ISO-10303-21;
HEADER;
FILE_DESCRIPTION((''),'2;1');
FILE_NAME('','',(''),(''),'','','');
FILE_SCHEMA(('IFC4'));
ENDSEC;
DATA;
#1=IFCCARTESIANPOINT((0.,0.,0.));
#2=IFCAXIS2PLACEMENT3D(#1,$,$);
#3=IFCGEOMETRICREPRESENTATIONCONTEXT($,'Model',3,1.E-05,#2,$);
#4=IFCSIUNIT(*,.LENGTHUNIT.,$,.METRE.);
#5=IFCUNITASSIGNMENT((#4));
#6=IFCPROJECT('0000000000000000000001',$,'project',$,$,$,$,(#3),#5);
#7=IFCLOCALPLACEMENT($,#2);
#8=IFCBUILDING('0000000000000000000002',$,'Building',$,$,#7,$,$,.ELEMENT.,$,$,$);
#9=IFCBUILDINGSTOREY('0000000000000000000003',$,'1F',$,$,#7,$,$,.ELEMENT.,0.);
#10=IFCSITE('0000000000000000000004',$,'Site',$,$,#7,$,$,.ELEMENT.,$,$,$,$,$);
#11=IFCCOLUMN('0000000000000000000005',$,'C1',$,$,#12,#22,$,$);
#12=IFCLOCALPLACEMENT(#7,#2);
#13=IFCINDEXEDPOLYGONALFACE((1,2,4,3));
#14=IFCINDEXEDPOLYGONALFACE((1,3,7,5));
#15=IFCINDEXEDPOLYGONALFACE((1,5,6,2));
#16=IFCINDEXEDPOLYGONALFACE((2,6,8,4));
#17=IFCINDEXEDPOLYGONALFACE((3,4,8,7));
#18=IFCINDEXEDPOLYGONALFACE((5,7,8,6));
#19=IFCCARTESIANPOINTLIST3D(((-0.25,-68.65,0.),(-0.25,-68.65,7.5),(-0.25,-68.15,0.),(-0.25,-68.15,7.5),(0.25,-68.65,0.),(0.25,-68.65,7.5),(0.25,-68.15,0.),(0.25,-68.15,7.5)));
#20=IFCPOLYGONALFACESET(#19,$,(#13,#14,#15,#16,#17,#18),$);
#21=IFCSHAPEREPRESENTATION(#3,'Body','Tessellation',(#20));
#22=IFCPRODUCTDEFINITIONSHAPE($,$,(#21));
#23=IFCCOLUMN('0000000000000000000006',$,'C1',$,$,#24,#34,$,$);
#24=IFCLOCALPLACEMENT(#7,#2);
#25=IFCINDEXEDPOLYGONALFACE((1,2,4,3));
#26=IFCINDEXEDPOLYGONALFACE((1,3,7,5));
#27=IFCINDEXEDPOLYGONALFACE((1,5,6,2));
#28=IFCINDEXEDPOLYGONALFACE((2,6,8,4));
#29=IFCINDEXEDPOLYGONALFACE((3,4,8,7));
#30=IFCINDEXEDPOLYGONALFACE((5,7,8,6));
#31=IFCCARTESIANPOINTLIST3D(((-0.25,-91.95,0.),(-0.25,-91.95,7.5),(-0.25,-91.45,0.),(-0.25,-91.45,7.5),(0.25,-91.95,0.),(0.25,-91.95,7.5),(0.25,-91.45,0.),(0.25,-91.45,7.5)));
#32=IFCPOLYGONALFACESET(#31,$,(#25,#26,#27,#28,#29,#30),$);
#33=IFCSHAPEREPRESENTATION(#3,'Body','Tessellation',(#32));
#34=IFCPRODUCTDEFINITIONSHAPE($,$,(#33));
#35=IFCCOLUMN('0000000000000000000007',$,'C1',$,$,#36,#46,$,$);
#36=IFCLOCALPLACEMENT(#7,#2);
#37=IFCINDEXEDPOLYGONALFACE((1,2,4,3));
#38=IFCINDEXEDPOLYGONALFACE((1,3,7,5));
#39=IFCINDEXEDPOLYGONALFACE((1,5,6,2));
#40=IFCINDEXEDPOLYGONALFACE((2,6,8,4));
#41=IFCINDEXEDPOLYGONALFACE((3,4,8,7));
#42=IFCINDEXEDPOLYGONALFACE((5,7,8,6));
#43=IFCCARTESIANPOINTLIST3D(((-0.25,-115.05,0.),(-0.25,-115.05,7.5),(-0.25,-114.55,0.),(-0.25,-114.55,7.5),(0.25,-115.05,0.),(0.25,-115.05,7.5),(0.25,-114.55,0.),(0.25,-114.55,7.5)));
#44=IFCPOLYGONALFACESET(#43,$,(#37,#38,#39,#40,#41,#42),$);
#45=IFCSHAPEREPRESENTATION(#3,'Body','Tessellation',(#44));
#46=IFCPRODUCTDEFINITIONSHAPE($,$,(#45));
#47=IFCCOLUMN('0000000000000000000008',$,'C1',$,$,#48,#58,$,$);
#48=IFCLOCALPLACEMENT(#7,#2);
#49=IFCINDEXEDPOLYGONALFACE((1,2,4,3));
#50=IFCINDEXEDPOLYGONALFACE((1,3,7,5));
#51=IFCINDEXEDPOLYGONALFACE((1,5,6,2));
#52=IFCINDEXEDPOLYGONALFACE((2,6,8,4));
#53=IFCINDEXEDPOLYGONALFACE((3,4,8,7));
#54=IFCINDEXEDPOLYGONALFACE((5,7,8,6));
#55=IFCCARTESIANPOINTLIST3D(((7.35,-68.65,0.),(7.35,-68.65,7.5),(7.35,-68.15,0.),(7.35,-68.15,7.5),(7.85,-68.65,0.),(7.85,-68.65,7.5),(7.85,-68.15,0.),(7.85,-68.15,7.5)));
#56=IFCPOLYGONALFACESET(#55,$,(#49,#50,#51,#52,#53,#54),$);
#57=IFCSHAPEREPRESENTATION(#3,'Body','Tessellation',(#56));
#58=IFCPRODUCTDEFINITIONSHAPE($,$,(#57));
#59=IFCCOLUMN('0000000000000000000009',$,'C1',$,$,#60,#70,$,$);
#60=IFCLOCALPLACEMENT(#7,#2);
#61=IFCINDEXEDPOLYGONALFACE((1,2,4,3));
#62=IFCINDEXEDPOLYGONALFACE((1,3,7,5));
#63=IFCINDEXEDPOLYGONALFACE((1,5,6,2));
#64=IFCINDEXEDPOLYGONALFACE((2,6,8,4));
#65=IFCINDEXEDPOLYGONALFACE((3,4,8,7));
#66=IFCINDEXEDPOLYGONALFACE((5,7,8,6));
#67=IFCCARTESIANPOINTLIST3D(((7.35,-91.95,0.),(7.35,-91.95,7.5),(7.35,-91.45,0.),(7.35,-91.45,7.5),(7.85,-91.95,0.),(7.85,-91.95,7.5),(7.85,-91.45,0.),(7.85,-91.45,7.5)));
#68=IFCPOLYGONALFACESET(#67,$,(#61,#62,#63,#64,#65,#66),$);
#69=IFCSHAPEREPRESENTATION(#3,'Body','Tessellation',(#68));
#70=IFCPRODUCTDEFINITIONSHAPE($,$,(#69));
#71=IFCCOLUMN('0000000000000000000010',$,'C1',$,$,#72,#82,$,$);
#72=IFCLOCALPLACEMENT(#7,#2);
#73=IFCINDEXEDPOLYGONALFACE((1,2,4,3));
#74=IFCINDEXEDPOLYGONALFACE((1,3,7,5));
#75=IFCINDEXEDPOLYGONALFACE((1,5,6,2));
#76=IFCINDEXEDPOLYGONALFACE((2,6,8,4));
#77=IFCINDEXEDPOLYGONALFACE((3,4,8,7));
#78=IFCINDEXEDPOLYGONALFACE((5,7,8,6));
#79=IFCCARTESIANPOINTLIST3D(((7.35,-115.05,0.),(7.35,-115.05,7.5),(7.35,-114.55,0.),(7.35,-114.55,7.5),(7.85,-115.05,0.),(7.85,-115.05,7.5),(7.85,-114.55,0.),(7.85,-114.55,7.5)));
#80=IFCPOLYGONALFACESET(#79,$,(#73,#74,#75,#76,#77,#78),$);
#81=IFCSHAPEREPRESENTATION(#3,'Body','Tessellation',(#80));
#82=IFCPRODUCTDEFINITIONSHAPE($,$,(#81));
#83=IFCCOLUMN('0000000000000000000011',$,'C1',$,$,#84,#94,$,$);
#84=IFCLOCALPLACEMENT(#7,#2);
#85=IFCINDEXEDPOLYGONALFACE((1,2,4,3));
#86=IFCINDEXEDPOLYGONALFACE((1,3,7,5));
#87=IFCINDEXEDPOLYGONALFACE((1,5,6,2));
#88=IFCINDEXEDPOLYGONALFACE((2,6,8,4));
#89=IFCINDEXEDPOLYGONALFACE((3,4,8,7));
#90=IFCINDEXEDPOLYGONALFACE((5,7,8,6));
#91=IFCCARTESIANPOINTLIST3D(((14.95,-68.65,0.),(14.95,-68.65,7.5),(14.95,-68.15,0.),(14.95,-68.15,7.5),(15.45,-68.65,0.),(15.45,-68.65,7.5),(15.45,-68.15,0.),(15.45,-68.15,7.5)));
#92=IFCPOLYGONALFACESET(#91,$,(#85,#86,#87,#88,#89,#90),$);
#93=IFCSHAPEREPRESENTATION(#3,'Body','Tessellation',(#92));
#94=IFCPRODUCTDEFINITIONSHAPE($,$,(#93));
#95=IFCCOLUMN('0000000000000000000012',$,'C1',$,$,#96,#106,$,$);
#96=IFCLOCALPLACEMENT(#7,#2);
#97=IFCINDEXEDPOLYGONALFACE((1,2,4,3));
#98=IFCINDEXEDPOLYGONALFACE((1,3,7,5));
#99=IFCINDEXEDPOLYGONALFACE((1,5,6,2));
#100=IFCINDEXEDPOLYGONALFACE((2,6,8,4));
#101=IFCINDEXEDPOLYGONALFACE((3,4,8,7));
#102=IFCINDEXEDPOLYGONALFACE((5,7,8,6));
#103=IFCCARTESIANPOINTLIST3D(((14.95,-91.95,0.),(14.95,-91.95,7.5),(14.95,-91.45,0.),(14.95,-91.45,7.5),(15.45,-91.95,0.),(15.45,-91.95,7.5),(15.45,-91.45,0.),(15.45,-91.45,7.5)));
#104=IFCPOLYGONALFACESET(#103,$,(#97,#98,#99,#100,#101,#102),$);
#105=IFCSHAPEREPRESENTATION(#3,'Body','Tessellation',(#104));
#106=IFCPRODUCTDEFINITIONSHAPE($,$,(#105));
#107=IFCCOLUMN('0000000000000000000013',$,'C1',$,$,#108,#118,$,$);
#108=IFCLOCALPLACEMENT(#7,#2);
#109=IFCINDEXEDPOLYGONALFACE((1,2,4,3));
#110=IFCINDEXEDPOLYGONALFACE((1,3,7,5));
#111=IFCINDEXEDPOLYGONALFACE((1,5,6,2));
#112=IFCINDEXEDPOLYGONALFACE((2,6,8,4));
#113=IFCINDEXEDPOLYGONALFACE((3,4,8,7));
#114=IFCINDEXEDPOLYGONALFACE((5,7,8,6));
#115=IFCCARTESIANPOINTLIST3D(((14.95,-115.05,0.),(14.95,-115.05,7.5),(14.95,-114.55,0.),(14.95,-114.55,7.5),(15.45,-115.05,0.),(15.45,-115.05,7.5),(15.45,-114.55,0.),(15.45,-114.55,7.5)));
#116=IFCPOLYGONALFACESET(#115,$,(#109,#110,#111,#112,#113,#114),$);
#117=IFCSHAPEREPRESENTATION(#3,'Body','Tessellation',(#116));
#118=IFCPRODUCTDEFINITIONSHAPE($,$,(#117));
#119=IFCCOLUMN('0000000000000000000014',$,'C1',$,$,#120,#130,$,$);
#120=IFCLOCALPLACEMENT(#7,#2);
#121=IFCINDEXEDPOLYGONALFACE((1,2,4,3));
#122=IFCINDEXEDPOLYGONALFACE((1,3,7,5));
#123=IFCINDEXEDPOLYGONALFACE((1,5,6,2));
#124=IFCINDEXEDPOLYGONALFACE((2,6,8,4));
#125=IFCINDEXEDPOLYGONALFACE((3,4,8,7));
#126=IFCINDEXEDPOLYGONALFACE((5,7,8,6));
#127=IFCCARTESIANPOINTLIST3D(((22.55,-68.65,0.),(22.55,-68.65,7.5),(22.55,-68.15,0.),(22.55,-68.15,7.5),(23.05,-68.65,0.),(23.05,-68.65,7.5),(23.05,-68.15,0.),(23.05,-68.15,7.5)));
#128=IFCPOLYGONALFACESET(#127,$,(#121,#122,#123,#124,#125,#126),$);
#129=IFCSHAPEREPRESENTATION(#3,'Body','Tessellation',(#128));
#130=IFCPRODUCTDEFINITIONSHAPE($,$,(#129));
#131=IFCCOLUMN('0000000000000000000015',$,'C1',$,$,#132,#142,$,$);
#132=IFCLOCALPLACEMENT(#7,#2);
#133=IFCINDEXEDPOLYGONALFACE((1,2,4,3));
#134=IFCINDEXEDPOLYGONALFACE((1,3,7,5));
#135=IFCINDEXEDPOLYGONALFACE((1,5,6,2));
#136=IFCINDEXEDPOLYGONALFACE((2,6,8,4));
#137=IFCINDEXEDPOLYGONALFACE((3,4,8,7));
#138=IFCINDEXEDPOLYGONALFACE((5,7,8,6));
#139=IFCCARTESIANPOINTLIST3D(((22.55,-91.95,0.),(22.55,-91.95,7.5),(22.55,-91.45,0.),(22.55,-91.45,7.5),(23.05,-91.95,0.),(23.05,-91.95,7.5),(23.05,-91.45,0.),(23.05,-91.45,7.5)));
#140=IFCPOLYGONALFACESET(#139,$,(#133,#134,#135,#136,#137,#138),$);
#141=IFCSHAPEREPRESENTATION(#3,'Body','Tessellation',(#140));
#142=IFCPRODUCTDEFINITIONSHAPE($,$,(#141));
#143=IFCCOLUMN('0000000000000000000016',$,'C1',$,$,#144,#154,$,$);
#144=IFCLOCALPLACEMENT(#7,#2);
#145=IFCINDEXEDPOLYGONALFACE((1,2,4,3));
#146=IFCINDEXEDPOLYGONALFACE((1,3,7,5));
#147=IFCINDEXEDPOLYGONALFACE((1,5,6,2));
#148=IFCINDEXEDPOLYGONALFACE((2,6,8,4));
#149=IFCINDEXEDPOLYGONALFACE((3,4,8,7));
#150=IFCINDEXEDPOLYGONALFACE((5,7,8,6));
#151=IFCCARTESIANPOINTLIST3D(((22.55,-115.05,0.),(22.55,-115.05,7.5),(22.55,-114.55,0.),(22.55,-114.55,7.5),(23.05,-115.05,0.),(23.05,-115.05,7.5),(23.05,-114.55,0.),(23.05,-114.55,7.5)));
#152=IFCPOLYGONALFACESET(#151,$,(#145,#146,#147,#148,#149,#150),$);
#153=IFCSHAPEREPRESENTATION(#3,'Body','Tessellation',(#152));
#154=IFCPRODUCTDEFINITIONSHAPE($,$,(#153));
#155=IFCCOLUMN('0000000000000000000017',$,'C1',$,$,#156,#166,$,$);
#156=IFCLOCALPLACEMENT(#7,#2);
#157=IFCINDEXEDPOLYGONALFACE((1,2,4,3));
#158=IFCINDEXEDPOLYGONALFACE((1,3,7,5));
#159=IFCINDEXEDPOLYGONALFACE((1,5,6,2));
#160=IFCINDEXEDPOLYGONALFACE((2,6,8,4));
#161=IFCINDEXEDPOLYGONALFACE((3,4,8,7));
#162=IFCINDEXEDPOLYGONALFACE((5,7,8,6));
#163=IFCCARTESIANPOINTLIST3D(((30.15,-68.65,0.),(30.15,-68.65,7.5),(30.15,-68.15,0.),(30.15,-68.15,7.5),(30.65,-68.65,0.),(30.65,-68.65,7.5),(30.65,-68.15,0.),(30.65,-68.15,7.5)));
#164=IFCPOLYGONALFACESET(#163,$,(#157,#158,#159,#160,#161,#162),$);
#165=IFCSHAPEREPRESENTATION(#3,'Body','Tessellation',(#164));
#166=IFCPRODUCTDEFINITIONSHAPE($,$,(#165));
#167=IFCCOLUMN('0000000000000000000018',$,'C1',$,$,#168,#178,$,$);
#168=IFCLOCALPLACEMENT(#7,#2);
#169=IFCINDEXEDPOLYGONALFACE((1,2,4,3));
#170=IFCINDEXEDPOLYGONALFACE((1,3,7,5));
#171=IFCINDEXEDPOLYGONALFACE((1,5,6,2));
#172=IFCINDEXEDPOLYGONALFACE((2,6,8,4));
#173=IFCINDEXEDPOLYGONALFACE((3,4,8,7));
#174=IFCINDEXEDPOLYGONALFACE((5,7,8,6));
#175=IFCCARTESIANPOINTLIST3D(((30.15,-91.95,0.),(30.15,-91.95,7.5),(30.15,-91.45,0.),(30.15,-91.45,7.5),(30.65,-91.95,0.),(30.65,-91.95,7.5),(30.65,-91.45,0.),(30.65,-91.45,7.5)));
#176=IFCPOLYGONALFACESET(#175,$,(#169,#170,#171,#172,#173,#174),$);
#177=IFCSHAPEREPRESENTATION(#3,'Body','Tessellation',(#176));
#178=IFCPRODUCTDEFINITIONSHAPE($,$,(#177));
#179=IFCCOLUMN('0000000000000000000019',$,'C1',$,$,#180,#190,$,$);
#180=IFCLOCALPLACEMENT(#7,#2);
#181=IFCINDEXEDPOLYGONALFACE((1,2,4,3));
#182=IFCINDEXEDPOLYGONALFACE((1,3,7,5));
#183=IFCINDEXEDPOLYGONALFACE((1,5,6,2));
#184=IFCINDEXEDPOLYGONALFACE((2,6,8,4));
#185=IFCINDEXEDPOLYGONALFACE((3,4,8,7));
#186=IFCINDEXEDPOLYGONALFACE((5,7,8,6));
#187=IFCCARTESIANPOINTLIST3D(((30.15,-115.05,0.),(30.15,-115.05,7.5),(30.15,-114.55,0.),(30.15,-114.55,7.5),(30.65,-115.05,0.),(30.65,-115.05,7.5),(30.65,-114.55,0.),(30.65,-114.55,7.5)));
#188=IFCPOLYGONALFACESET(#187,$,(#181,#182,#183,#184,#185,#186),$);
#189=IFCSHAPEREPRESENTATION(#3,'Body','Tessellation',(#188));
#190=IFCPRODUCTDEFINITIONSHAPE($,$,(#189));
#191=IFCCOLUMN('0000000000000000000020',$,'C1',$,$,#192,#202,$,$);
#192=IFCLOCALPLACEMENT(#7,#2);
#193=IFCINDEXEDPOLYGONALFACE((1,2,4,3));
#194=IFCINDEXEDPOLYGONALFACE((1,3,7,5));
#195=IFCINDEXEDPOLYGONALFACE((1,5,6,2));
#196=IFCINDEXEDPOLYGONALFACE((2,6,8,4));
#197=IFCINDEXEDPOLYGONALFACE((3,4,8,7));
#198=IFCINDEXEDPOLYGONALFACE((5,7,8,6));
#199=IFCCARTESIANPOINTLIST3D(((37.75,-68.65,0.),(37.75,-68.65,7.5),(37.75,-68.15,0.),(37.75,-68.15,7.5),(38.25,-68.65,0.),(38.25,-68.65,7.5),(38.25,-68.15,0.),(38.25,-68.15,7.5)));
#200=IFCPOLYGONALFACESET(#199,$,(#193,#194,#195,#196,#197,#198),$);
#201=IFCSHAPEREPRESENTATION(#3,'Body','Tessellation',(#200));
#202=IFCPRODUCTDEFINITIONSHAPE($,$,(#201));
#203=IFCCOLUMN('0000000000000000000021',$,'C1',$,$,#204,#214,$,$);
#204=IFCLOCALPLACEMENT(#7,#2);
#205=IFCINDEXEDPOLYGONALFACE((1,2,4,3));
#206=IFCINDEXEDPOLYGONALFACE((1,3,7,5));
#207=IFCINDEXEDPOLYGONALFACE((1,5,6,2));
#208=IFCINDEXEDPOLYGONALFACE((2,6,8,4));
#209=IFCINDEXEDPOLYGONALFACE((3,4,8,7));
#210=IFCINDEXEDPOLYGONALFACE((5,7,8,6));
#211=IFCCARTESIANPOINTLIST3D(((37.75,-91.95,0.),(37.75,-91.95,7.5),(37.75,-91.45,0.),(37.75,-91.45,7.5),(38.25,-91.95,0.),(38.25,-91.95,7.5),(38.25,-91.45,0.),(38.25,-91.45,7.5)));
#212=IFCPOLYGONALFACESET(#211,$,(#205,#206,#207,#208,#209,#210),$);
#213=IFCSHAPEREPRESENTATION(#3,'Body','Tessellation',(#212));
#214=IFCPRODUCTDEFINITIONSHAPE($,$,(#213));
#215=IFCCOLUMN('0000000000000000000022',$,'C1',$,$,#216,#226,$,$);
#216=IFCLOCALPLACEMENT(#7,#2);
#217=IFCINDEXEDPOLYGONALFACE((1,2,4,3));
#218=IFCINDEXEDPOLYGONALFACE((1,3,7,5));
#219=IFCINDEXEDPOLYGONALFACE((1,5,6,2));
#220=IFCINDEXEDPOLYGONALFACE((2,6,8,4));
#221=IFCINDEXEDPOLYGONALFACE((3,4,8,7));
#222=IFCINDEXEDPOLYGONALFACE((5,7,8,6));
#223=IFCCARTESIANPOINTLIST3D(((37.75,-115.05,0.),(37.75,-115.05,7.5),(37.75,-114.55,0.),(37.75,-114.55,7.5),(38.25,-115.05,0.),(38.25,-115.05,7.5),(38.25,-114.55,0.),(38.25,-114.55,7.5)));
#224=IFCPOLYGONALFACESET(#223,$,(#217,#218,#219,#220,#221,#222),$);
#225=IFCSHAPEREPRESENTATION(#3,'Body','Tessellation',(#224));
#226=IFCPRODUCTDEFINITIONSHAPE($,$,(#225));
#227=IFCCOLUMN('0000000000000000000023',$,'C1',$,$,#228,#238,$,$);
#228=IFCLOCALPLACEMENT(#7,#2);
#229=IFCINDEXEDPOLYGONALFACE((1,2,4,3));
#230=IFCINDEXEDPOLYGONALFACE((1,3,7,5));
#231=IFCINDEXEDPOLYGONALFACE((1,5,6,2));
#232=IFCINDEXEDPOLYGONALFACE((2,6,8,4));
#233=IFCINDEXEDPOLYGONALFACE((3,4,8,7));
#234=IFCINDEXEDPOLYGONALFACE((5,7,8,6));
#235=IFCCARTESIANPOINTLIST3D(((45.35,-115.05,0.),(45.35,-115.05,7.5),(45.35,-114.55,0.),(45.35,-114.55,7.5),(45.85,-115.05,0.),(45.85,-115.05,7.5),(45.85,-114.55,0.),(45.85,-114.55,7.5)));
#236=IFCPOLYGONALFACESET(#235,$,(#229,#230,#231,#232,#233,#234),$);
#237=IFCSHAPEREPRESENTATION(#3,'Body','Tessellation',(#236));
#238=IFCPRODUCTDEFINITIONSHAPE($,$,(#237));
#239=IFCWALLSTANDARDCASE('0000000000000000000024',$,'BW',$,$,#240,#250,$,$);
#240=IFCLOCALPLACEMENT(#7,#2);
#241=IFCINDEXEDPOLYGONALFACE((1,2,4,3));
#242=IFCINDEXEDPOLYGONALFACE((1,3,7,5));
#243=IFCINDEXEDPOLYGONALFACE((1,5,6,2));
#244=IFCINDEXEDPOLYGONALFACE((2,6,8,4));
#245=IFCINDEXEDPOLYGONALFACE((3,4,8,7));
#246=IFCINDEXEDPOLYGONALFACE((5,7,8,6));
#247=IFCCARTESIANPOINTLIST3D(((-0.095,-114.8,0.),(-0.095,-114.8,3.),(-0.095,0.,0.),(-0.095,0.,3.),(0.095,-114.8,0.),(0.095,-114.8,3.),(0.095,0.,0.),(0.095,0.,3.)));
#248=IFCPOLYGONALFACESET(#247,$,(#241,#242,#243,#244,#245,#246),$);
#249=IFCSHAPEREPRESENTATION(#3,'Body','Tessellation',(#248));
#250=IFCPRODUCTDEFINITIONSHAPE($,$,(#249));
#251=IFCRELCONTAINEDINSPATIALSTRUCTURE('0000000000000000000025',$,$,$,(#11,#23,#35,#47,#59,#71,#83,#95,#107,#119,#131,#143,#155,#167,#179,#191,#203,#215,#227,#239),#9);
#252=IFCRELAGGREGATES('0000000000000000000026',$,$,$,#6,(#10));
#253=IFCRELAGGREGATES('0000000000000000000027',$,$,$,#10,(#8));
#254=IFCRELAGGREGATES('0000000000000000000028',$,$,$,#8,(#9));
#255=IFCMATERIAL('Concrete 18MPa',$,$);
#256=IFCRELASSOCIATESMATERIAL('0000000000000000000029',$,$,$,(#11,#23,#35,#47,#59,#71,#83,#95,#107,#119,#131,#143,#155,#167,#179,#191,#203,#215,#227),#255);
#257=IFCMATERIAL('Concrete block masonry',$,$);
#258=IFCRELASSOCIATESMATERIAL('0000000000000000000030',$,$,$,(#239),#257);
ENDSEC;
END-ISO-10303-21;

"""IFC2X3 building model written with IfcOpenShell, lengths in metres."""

from ifc_helpers import new_model, si_unit, frame, origin, origin_2d, place, context, project, spatial, rectangle, extrude, material, element, save


model = new_model("IFC2X3")

# Units and contexts
model_context = context("Model", 3, precision=1e-05, world=origin())
ifc_project = project(units=[si_unit("LENGTHUNIT", "METRE")], contexts=[model_context])

# Site, building, storey
placement = place(None, origin())
site = spatial("IfcSite", under=ifc_project, at=placement, Name="Site", CompositionType="ELEMENT")
building = spatial("IfcBuilding", under=site, at=placement, Name="Building", CompositionType="ELEMENT")
storey = spatial("IfcBuildingStorey", under=building, at=placement, Name="1F", CompositionType="ELEMENT", Elevation=0.0)

# Columns
ifc_material_1 = material(Name="Concrete 18MPa")
for number, where, name in (
    (1, (0.0, -68.4, 0.0), "C1"),
    (2, (0.0, -91.7, 0.0), "C1"),
    (3, (0.0, -114.8, 0.0), "C1"),
    (4, (7.6, -68.4, 0.0), "C1"),
    (5, (7.6, -91.7, 0.0), "C1"),
    (6, (7.6, -114.8, 0.0), "C1"),
    (7, (15.2, -68.4, 0.0), "C1"),
    (8, (15.2, -91.7, 0.0), "C1"),
    (9, (15.2, -114.8, 0.0), "C1"),
    (10, (22.8, -68.4, 0.0), "C1"),
    (11, (22.8, -91.7, 0.0), "C1"),
    (12, (22.8, -114.8, 0.0), "C1"),
    (13, (30.4, -68.4, 0.0), "C1"),
    (14, (30.4, -91.7, 0.0), "C1"),
    (15, (30.4, -114.8, 0.0), "C1"),
    (16, (38.0, -68.4, 0.0), "C1"),
    (17, (38.0, -91.7, 0.0), "C1"),
    (18, (38.0, -114.8, 0.0), "C1"),
    (19, (45.6, -114.8, 0.0), "C1"),
):
    element("IfcColumn", number, at=place(None, frame(where)), inside=storey, material=ifc_material_1, Name=name, context=model_context, shape_type="SweptSolid", body=[
        extrude(rectangle(XDim=0.5, YDim=0.5, at=origin_2d()), origin(), (0.0, 0.0, 1.0), 7.5),
    ])

# Wall
ifc_material_2 = material(Name="Concrete block masonry")
wall_placement = place(None, frame((0.0, -57.4, 0.0)))
element("IfcWallStandardCase", 20, at=wall_placement, inside=storey, material=ifc_material_2, Name="BW", context=model_context, shape_type="SweptSolid", body=[
    extrude(rectangle(XDim=0.19, YDim=114.8, at=origin_2d()), origin(), (0.0, 0.0, 1.0), 3.0),
])

save(model, "model.ifc")
